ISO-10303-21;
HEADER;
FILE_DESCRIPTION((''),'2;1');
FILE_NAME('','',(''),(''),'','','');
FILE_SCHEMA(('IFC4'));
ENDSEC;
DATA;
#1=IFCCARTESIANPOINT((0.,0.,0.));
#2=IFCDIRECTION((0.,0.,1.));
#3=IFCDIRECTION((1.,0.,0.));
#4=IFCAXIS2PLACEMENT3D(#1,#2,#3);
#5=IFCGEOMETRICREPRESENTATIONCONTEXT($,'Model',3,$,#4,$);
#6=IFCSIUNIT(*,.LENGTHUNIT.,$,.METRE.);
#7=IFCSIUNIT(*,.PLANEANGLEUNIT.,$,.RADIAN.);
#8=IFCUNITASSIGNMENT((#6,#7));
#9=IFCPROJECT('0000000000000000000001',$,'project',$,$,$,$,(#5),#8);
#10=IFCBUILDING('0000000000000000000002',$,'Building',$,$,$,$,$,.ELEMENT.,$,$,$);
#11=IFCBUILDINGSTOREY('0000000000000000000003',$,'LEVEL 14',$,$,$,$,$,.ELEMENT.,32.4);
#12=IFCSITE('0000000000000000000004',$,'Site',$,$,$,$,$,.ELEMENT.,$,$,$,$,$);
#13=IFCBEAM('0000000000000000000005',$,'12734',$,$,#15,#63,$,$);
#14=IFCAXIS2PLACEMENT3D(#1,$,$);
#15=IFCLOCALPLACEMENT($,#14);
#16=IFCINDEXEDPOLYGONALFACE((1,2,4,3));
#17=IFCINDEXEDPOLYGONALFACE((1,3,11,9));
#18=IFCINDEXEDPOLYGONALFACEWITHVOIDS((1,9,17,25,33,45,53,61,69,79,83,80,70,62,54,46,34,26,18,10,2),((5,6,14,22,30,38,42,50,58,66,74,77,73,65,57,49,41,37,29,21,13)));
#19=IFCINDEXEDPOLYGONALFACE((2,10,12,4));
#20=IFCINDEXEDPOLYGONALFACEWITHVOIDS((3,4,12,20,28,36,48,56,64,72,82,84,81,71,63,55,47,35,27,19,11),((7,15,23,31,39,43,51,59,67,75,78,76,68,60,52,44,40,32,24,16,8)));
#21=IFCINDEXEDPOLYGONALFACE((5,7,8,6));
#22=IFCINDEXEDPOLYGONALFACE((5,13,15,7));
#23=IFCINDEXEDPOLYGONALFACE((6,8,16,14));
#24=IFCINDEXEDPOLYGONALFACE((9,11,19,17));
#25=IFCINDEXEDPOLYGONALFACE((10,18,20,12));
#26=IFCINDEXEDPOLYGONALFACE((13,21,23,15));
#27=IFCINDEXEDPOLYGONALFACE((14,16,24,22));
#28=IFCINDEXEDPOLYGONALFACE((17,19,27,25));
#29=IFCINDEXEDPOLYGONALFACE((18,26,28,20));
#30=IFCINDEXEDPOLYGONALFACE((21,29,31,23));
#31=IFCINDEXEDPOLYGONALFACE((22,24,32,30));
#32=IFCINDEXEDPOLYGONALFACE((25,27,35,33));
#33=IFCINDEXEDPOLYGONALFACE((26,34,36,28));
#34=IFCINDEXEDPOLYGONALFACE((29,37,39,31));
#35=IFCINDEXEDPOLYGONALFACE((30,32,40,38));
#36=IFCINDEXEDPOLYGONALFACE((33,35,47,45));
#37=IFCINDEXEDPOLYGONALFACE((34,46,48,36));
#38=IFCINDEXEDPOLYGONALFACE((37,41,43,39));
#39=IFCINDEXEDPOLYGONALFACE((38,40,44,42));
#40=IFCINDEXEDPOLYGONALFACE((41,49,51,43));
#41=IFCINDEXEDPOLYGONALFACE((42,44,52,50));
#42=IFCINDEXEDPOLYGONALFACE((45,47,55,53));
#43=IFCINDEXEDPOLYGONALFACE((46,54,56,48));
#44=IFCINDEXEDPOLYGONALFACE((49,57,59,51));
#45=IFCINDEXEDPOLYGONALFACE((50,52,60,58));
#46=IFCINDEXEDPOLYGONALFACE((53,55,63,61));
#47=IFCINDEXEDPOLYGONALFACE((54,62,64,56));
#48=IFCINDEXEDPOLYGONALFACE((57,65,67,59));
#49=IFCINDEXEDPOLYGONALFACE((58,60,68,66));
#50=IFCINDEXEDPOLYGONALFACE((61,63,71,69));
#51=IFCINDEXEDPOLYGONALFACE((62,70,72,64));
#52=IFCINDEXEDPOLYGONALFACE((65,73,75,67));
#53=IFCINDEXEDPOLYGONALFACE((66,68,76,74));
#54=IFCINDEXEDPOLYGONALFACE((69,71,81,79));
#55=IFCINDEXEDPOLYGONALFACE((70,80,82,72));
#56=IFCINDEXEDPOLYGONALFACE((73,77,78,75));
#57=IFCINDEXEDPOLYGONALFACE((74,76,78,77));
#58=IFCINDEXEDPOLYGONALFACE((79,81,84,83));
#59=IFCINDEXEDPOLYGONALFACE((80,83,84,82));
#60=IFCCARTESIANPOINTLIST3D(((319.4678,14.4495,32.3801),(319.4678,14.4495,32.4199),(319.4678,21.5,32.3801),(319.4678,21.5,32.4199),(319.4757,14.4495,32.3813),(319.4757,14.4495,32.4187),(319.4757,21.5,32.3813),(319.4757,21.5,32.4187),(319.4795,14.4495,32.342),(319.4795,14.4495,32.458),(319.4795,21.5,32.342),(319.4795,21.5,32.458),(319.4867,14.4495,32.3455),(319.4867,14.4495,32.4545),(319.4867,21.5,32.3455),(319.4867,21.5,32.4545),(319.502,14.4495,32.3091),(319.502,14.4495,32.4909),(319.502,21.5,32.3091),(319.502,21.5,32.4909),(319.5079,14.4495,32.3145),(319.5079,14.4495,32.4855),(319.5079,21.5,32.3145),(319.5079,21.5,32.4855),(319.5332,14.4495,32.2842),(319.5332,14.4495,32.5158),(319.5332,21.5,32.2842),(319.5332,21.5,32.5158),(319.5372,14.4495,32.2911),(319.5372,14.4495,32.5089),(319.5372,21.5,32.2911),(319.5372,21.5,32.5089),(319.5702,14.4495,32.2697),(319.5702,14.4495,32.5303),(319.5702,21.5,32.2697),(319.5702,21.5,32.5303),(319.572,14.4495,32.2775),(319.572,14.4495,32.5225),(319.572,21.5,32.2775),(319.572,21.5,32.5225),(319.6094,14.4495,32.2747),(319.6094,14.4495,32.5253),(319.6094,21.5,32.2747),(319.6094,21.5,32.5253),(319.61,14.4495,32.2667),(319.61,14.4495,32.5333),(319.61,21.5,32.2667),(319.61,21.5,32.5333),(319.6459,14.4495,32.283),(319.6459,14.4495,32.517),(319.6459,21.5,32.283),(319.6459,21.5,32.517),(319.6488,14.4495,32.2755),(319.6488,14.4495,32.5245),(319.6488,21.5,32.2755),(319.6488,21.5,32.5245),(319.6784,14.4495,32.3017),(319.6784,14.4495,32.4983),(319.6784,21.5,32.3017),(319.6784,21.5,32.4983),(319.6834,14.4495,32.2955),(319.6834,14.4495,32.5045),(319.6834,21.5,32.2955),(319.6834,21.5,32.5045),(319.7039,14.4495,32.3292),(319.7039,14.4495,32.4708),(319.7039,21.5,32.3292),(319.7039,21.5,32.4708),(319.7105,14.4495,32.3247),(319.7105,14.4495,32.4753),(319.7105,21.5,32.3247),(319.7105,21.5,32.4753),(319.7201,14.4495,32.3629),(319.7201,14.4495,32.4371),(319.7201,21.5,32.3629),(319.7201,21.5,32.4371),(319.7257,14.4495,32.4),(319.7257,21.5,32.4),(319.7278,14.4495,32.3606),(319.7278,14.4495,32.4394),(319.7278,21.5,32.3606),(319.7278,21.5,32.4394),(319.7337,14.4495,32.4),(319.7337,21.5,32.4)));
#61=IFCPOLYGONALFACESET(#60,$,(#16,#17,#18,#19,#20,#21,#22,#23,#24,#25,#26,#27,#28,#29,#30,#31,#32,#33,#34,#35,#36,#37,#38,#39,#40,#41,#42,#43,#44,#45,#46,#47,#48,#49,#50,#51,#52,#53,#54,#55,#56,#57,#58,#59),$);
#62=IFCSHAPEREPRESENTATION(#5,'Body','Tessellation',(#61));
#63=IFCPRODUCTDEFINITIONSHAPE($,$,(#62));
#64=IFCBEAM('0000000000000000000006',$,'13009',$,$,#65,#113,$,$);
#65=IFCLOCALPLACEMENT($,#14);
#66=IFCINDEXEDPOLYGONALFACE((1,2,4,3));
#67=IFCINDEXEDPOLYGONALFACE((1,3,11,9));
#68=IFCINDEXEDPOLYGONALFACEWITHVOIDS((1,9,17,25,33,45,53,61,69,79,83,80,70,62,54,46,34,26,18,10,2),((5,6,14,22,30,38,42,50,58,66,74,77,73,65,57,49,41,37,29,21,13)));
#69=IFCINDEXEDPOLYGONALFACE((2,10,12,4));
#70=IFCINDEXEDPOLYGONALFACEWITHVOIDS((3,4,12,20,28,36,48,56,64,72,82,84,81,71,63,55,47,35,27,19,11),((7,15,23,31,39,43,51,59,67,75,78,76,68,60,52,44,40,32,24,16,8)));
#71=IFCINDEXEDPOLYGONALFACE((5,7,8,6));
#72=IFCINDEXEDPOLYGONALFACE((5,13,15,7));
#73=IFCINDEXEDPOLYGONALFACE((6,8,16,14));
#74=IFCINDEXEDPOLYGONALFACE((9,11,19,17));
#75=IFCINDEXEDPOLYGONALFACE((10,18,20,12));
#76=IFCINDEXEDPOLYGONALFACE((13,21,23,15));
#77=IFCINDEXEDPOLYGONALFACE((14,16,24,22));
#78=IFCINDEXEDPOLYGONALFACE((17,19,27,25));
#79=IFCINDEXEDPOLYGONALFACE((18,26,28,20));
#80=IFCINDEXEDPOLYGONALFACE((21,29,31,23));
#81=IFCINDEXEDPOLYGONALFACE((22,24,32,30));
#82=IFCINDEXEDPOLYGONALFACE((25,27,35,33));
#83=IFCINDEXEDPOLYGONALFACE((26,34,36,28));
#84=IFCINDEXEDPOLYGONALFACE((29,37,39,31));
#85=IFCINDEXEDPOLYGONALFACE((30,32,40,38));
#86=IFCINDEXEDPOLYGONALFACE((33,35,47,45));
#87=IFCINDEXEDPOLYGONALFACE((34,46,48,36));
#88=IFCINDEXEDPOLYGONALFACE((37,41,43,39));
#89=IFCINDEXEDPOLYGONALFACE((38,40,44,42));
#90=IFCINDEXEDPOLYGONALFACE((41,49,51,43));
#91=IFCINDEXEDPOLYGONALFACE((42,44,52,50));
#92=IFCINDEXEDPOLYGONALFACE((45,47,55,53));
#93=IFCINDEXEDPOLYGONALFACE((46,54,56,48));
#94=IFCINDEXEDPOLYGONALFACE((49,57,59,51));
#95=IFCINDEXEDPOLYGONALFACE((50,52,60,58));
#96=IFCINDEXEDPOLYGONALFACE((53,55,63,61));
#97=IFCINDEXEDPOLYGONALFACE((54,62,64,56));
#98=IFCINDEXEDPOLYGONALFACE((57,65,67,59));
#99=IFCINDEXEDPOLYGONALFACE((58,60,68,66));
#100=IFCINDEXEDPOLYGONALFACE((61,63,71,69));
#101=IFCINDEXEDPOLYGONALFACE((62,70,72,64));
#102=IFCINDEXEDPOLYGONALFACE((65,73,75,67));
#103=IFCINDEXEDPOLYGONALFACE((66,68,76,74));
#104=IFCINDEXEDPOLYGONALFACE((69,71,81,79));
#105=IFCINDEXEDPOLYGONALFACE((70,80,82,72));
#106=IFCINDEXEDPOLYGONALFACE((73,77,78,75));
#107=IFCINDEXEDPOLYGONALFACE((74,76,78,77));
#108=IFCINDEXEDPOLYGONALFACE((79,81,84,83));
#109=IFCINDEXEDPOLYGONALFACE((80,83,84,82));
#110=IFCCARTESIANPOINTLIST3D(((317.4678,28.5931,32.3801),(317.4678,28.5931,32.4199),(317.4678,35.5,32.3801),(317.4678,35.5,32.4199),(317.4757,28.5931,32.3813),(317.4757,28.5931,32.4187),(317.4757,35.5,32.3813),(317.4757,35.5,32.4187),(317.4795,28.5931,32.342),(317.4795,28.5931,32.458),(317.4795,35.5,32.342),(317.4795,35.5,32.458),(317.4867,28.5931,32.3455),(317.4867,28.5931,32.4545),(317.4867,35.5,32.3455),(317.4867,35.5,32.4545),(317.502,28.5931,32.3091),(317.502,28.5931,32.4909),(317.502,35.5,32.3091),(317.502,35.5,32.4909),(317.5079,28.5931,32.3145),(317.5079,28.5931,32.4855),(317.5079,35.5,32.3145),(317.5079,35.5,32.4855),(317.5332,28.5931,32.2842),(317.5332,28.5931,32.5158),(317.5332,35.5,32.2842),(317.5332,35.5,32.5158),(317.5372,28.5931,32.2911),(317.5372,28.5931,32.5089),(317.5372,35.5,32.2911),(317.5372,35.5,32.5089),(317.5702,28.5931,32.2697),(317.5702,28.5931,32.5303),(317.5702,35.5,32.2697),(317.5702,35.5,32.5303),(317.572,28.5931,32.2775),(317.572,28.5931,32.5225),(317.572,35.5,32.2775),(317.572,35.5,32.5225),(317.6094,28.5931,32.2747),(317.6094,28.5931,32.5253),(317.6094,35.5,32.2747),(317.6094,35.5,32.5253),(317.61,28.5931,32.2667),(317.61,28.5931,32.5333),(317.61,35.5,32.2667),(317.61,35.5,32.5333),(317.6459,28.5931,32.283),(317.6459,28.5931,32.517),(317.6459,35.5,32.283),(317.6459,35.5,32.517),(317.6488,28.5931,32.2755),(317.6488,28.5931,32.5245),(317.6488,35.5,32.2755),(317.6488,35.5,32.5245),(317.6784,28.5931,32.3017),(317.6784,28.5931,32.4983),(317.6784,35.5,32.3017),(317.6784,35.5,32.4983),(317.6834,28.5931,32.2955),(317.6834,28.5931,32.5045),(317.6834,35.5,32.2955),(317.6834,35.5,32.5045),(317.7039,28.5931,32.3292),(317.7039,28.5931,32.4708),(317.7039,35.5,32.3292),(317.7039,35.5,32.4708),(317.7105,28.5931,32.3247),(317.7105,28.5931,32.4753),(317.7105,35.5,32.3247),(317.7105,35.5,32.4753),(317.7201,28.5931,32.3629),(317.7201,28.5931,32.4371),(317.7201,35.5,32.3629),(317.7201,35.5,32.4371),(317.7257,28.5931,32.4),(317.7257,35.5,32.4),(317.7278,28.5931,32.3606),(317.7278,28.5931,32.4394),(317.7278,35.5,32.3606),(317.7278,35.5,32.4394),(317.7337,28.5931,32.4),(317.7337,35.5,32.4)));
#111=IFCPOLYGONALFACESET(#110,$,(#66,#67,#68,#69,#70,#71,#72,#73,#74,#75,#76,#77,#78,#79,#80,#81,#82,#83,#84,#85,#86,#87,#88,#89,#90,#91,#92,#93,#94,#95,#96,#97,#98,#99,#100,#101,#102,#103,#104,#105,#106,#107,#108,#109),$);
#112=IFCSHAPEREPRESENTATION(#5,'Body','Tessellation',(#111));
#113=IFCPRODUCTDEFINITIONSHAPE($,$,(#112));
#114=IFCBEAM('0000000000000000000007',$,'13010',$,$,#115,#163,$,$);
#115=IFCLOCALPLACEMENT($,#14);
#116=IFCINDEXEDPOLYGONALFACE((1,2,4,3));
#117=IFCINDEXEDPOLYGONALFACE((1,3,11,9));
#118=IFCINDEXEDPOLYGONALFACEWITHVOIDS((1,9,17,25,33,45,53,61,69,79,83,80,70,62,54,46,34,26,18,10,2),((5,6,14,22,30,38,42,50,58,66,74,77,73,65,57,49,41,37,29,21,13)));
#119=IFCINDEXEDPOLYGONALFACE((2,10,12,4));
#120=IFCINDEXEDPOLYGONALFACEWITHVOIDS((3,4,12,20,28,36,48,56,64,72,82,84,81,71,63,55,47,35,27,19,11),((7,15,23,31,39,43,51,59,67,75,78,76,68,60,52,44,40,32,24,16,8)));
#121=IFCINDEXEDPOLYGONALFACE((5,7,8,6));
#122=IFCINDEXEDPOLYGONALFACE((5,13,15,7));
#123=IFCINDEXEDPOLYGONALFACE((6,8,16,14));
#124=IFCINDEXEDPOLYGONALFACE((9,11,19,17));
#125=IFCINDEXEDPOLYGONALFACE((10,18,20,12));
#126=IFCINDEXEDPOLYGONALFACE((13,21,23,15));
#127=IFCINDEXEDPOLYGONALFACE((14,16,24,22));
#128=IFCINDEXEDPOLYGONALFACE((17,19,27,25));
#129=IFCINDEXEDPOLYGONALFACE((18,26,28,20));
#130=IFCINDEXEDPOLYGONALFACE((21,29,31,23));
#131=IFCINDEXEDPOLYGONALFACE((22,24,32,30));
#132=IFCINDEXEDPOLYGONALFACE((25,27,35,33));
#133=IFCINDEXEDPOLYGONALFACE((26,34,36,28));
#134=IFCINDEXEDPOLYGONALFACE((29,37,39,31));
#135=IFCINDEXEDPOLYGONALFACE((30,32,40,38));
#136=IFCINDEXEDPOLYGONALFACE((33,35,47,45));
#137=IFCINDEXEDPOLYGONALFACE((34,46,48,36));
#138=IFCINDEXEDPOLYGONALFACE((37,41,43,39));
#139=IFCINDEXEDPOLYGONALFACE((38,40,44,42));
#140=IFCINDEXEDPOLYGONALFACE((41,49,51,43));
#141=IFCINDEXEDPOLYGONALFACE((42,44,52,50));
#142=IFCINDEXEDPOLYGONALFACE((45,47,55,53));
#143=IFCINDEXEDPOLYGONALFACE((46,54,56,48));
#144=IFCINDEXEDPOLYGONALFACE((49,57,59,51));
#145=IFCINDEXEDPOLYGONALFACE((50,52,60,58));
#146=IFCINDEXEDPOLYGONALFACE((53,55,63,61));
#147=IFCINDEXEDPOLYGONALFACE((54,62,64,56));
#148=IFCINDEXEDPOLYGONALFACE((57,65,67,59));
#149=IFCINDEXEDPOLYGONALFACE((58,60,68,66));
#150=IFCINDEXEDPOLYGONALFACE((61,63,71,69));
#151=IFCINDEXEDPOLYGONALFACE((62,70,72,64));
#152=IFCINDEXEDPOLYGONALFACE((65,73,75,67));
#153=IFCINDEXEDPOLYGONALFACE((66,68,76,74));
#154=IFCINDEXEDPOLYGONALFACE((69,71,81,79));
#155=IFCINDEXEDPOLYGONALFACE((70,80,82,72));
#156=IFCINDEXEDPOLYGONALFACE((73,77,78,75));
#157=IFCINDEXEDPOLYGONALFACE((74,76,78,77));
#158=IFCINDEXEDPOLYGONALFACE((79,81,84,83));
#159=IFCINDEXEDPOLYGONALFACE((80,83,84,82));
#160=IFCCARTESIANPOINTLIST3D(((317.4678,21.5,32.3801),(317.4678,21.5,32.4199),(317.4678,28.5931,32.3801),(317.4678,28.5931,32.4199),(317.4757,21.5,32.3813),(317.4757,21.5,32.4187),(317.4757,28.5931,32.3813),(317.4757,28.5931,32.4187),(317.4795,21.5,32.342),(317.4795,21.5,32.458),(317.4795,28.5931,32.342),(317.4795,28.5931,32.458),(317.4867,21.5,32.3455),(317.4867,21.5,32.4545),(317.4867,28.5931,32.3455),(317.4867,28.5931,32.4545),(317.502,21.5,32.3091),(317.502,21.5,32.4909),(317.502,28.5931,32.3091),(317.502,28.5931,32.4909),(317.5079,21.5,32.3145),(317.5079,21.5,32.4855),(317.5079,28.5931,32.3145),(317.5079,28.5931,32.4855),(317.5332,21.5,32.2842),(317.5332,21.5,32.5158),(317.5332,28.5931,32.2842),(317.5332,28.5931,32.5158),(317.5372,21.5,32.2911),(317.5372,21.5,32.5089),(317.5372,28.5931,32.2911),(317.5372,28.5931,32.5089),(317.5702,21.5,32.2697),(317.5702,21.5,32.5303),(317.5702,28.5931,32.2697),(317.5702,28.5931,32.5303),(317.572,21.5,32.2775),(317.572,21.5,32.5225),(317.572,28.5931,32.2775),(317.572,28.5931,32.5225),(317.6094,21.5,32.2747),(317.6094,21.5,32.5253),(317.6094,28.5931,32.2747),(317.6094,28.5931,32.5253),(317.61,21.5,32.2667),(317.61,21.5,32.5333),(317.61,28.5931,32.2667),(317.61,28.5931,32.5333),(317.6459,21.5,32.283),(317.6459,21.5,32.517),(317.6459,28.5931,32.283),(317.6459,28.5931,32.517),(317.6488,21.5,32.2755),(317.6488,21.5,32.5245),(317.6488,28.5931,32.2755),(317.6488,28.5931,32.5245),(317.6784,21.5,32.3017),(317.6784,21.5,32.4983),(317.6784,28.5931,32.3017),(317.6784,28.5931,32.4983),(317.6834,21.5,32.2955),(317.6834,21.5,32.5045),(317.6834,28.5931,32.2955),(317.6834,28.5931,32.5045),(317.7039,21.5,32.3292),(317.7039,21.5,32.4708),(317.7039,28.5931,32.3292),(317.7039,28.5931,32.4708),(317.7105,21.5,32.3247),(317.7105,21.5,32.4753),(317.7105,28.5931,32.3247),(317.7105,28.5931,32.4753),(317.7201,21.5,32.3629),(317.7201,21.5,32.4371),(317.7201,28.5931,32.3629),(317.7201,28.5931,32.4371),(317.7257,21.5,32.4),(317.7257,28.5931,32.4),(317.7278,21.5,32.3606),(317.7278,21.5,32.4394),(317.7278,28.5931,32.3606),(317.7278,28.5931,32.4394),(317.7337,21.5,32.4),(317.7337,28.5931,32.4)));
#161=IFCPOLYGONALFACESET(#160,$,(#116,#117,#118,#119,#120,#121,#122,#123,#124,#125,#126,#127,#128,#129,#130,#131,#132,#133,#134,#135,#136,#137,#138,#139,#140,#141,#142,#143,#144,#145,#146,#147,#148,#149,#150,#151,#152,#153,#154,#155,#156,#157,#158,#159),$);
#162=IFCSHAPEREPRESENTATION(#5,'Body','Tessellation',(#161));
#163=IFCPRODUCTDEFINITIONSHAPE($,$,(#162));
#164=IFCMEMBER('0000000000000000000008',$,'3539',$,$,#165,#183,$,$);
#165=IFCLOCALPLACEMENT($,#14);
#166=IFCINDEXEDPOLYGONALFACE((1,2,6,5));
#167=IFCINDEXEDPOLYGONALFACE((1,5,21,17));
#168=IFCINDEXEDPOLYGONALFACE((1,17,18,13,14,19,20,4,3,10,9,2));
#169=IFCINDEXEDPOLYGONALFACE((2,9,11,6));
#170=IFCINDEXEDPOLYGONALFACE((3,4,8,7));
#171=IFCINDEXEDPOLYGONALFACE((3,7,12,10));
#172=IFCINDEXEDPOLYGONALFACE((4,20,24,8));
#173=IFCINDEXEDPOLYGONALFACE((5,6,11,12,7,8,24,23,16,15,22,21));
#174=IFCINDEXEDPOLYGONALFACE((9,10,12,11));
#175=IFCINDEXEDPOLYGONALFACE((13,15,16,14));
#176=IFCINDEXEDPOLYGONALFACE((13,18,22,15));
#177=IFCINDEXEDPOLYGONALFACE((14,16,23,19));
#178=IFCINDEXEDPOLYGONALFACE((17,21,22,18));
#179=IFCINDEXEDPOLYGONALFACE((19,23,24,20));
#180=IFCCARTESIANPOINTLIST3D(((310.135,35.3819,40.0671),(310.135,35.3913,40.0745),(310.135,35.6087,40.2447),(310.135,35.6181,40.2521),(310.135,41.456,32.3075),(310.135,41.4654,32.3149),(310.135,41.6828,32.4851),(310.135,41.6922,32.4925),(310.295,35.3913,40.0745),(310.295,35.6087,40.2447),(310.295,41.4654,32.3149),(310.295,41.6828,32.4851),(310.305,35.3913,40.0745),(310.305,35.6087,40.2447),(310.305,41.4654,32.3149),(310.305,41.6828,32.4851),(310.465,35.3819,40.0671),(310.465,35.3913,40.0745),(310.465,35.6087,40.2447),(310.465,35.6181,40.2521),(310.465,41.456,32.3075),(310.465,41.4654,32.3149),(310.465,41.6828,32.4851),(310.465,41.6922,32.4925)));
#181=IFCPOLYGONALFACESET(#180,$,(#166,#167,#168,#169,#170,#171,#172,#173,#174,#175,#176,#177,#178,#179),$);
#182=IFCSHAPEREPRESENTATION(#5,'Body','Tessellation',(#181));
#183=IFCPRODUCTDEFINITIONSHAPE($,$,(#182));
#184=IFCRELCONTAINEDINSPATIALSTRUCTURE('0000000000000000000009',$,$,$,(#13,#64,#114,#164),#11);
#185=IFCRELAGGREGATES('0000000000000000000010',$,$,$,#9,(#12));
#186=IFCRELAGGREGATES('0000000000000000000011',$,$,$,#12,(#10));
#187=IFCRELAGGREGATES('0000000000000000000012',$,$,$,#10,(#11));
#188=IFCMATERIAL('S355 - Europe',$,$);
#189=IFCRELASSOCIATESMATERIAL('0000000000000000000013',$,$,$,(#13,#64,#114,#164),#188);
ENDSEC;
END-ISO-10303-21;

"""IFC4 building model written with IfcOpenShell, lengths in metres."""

from ifc_helpers import new_model, si_unit, frame, origin_with_axes, origin_2d_with_axis, place, context, project, spatial, hollow_circle, i_section, extrude, material, material_profile, profile_set, profile_usage, element, save


model = new_model("IFC4")

# Units and contexts
model_context = context("Model", 3, world=origin_with_axes())
ifc_project = project(units=[si_unit("LENGTHUNIT", "METRE"), si_unit("PLANEANGLEUNIT", "RADIAN")], contexts=[model_context])

# Site, building, storey
site = spatial("IfcSite", under=ifc_project, Name="Site", CompositionType="ELEMENT")
building = spatial("IfcBuilding", under=site, Name="Building", CompositionType="ELEMENT")
storey = spatial("IfcBuildingStorey", under=building, Name="LEVEL 14", CompositionType="ELEMENT", Elevation=32.4)

# Shared definitions
ifc_material = material(Name="S355 - Europe")

# Beams
ifc_material_profile_1 = material_profile(ifc_material, hollow_circle(Radius=0.1337, WallThickness=0.008, at=origin_2d_with_axis()))
ifc_profile_set_1 = profile_set([ifc_material_profile_1])
ifc_profile_usage_1 = profile_usage(ifc_profile_set_1, cardinal=10)
beam_1_placement = place(None, frame((319.6, 21.5, 32.4), z_axis=(0.0, -1.0, 0.0), x_axis=(1.0, 0.0, 0.0)))
element("IfcBeam", 1, at=beam_1_placement, inside=storey, material=ifc_profile_usage_1, Name="12734", context=model_context, shape_type="SweptSolid", body=[
    extrude(hollow_circle(Radius=0.1337, WallThickness=0.008, at=origin_2d_with_axis()), origin_with_axes(), (0.0, 0.0, 1.0), 7.0505),
])
ifc_material_profile_2 = material_profile(ifc_material, hollow_circle(Radius=0.1337, WallThickness=0.008, at=origin_2d_with_axis()))
ifc_profile_set_2 = profile_set([ifc_material_profile_2])
ifc_profile_usage_2 = profile_usage(ifc_profile_set_2, cardinal=10)
beam_2_placement = place(None, frame((317.6, 35.5, 32.4), z_axis=(0.0, -1.0, 0.0), x_axis=(1.0, 0.0, 0.0)))
element("IfcBeam", 2, at=beam_2_placement, inside=storey, material=ifc_profile_usage_2, Name="13009", context=model_context, shape_type="SweptSolid", body=[
    extrude(hollow_circle(Radius=0.1337, WallThickness=0.008, at=origin_2d_with_axis()), origin_with_axes(), (0.0, 0.0, 1.0), 6.9069),
])
ifc_material_profile_3 = material_profile(ifc_material, hollow_circle(Radius=0.1337, WallThickness=0.008, at=origin_2d_with_axis()))
ifc_profile_set_3 = profile_set([ifc_material_profile_3])
ifc_profile_usage_3 = profile_usage(ifc_profile_set_3, cardinal=10)
beam_3_placement = place(None, frame((317.6, 28.5931, 32.4), z_axis=(0.0, -1.0, 0.0), x_axis=(1.0, 0.0, 0.0)))
element("IfcBeam", 3, at=beam_3_placement, inside=storey, material=ifc_profile_usage_3, Name="13010", context=model_context, shape_type="SweptSolid", body=[
    extrude(hollow_circle(Radius=0.1337, WallThickness=0.008, at=origin_2d_with_axis()), origin_with_axes(), (0.0, 0.0, 1.0), 7.0931),
])

# Member
ifc_material_profile_4 = material_profile(ifc_material, i_section(OverallWidth=0.33, OverallDepth=0.3, WebThickness=0.01, FlangeThickness=0.012, at=origin_2d_with_axis()))
ifc_profile_set_4 = profile_set([ifc_material_profile_4])
ifc_profile_usage_4 = profile_usage(ifc_profile_set_4, cardinal=10)
member_1_placement = place(None, frame((310.3, 35.5, 40.1596), z_axis=(0.0, 0.616394, -0.787438), x_axis=(-1.0, 0.0, 0.0)))
element("IfcMember", 4, at=member_1_placement, inside=storey, material=ifc_profile_usage_4, Name="3539", context=model_context, shape_type="SweptSolid", body=[
    extrude(i_section(OverallWidth=0.33, OverallDepth=0.3, WebThickness=0.01, FlangeThickness=0.012, at=origin_2d_with_axis()), origin_with_axes(), (0.0, 0.0, 1.0), 9.8542),
])

save(model, "model.ifc")
